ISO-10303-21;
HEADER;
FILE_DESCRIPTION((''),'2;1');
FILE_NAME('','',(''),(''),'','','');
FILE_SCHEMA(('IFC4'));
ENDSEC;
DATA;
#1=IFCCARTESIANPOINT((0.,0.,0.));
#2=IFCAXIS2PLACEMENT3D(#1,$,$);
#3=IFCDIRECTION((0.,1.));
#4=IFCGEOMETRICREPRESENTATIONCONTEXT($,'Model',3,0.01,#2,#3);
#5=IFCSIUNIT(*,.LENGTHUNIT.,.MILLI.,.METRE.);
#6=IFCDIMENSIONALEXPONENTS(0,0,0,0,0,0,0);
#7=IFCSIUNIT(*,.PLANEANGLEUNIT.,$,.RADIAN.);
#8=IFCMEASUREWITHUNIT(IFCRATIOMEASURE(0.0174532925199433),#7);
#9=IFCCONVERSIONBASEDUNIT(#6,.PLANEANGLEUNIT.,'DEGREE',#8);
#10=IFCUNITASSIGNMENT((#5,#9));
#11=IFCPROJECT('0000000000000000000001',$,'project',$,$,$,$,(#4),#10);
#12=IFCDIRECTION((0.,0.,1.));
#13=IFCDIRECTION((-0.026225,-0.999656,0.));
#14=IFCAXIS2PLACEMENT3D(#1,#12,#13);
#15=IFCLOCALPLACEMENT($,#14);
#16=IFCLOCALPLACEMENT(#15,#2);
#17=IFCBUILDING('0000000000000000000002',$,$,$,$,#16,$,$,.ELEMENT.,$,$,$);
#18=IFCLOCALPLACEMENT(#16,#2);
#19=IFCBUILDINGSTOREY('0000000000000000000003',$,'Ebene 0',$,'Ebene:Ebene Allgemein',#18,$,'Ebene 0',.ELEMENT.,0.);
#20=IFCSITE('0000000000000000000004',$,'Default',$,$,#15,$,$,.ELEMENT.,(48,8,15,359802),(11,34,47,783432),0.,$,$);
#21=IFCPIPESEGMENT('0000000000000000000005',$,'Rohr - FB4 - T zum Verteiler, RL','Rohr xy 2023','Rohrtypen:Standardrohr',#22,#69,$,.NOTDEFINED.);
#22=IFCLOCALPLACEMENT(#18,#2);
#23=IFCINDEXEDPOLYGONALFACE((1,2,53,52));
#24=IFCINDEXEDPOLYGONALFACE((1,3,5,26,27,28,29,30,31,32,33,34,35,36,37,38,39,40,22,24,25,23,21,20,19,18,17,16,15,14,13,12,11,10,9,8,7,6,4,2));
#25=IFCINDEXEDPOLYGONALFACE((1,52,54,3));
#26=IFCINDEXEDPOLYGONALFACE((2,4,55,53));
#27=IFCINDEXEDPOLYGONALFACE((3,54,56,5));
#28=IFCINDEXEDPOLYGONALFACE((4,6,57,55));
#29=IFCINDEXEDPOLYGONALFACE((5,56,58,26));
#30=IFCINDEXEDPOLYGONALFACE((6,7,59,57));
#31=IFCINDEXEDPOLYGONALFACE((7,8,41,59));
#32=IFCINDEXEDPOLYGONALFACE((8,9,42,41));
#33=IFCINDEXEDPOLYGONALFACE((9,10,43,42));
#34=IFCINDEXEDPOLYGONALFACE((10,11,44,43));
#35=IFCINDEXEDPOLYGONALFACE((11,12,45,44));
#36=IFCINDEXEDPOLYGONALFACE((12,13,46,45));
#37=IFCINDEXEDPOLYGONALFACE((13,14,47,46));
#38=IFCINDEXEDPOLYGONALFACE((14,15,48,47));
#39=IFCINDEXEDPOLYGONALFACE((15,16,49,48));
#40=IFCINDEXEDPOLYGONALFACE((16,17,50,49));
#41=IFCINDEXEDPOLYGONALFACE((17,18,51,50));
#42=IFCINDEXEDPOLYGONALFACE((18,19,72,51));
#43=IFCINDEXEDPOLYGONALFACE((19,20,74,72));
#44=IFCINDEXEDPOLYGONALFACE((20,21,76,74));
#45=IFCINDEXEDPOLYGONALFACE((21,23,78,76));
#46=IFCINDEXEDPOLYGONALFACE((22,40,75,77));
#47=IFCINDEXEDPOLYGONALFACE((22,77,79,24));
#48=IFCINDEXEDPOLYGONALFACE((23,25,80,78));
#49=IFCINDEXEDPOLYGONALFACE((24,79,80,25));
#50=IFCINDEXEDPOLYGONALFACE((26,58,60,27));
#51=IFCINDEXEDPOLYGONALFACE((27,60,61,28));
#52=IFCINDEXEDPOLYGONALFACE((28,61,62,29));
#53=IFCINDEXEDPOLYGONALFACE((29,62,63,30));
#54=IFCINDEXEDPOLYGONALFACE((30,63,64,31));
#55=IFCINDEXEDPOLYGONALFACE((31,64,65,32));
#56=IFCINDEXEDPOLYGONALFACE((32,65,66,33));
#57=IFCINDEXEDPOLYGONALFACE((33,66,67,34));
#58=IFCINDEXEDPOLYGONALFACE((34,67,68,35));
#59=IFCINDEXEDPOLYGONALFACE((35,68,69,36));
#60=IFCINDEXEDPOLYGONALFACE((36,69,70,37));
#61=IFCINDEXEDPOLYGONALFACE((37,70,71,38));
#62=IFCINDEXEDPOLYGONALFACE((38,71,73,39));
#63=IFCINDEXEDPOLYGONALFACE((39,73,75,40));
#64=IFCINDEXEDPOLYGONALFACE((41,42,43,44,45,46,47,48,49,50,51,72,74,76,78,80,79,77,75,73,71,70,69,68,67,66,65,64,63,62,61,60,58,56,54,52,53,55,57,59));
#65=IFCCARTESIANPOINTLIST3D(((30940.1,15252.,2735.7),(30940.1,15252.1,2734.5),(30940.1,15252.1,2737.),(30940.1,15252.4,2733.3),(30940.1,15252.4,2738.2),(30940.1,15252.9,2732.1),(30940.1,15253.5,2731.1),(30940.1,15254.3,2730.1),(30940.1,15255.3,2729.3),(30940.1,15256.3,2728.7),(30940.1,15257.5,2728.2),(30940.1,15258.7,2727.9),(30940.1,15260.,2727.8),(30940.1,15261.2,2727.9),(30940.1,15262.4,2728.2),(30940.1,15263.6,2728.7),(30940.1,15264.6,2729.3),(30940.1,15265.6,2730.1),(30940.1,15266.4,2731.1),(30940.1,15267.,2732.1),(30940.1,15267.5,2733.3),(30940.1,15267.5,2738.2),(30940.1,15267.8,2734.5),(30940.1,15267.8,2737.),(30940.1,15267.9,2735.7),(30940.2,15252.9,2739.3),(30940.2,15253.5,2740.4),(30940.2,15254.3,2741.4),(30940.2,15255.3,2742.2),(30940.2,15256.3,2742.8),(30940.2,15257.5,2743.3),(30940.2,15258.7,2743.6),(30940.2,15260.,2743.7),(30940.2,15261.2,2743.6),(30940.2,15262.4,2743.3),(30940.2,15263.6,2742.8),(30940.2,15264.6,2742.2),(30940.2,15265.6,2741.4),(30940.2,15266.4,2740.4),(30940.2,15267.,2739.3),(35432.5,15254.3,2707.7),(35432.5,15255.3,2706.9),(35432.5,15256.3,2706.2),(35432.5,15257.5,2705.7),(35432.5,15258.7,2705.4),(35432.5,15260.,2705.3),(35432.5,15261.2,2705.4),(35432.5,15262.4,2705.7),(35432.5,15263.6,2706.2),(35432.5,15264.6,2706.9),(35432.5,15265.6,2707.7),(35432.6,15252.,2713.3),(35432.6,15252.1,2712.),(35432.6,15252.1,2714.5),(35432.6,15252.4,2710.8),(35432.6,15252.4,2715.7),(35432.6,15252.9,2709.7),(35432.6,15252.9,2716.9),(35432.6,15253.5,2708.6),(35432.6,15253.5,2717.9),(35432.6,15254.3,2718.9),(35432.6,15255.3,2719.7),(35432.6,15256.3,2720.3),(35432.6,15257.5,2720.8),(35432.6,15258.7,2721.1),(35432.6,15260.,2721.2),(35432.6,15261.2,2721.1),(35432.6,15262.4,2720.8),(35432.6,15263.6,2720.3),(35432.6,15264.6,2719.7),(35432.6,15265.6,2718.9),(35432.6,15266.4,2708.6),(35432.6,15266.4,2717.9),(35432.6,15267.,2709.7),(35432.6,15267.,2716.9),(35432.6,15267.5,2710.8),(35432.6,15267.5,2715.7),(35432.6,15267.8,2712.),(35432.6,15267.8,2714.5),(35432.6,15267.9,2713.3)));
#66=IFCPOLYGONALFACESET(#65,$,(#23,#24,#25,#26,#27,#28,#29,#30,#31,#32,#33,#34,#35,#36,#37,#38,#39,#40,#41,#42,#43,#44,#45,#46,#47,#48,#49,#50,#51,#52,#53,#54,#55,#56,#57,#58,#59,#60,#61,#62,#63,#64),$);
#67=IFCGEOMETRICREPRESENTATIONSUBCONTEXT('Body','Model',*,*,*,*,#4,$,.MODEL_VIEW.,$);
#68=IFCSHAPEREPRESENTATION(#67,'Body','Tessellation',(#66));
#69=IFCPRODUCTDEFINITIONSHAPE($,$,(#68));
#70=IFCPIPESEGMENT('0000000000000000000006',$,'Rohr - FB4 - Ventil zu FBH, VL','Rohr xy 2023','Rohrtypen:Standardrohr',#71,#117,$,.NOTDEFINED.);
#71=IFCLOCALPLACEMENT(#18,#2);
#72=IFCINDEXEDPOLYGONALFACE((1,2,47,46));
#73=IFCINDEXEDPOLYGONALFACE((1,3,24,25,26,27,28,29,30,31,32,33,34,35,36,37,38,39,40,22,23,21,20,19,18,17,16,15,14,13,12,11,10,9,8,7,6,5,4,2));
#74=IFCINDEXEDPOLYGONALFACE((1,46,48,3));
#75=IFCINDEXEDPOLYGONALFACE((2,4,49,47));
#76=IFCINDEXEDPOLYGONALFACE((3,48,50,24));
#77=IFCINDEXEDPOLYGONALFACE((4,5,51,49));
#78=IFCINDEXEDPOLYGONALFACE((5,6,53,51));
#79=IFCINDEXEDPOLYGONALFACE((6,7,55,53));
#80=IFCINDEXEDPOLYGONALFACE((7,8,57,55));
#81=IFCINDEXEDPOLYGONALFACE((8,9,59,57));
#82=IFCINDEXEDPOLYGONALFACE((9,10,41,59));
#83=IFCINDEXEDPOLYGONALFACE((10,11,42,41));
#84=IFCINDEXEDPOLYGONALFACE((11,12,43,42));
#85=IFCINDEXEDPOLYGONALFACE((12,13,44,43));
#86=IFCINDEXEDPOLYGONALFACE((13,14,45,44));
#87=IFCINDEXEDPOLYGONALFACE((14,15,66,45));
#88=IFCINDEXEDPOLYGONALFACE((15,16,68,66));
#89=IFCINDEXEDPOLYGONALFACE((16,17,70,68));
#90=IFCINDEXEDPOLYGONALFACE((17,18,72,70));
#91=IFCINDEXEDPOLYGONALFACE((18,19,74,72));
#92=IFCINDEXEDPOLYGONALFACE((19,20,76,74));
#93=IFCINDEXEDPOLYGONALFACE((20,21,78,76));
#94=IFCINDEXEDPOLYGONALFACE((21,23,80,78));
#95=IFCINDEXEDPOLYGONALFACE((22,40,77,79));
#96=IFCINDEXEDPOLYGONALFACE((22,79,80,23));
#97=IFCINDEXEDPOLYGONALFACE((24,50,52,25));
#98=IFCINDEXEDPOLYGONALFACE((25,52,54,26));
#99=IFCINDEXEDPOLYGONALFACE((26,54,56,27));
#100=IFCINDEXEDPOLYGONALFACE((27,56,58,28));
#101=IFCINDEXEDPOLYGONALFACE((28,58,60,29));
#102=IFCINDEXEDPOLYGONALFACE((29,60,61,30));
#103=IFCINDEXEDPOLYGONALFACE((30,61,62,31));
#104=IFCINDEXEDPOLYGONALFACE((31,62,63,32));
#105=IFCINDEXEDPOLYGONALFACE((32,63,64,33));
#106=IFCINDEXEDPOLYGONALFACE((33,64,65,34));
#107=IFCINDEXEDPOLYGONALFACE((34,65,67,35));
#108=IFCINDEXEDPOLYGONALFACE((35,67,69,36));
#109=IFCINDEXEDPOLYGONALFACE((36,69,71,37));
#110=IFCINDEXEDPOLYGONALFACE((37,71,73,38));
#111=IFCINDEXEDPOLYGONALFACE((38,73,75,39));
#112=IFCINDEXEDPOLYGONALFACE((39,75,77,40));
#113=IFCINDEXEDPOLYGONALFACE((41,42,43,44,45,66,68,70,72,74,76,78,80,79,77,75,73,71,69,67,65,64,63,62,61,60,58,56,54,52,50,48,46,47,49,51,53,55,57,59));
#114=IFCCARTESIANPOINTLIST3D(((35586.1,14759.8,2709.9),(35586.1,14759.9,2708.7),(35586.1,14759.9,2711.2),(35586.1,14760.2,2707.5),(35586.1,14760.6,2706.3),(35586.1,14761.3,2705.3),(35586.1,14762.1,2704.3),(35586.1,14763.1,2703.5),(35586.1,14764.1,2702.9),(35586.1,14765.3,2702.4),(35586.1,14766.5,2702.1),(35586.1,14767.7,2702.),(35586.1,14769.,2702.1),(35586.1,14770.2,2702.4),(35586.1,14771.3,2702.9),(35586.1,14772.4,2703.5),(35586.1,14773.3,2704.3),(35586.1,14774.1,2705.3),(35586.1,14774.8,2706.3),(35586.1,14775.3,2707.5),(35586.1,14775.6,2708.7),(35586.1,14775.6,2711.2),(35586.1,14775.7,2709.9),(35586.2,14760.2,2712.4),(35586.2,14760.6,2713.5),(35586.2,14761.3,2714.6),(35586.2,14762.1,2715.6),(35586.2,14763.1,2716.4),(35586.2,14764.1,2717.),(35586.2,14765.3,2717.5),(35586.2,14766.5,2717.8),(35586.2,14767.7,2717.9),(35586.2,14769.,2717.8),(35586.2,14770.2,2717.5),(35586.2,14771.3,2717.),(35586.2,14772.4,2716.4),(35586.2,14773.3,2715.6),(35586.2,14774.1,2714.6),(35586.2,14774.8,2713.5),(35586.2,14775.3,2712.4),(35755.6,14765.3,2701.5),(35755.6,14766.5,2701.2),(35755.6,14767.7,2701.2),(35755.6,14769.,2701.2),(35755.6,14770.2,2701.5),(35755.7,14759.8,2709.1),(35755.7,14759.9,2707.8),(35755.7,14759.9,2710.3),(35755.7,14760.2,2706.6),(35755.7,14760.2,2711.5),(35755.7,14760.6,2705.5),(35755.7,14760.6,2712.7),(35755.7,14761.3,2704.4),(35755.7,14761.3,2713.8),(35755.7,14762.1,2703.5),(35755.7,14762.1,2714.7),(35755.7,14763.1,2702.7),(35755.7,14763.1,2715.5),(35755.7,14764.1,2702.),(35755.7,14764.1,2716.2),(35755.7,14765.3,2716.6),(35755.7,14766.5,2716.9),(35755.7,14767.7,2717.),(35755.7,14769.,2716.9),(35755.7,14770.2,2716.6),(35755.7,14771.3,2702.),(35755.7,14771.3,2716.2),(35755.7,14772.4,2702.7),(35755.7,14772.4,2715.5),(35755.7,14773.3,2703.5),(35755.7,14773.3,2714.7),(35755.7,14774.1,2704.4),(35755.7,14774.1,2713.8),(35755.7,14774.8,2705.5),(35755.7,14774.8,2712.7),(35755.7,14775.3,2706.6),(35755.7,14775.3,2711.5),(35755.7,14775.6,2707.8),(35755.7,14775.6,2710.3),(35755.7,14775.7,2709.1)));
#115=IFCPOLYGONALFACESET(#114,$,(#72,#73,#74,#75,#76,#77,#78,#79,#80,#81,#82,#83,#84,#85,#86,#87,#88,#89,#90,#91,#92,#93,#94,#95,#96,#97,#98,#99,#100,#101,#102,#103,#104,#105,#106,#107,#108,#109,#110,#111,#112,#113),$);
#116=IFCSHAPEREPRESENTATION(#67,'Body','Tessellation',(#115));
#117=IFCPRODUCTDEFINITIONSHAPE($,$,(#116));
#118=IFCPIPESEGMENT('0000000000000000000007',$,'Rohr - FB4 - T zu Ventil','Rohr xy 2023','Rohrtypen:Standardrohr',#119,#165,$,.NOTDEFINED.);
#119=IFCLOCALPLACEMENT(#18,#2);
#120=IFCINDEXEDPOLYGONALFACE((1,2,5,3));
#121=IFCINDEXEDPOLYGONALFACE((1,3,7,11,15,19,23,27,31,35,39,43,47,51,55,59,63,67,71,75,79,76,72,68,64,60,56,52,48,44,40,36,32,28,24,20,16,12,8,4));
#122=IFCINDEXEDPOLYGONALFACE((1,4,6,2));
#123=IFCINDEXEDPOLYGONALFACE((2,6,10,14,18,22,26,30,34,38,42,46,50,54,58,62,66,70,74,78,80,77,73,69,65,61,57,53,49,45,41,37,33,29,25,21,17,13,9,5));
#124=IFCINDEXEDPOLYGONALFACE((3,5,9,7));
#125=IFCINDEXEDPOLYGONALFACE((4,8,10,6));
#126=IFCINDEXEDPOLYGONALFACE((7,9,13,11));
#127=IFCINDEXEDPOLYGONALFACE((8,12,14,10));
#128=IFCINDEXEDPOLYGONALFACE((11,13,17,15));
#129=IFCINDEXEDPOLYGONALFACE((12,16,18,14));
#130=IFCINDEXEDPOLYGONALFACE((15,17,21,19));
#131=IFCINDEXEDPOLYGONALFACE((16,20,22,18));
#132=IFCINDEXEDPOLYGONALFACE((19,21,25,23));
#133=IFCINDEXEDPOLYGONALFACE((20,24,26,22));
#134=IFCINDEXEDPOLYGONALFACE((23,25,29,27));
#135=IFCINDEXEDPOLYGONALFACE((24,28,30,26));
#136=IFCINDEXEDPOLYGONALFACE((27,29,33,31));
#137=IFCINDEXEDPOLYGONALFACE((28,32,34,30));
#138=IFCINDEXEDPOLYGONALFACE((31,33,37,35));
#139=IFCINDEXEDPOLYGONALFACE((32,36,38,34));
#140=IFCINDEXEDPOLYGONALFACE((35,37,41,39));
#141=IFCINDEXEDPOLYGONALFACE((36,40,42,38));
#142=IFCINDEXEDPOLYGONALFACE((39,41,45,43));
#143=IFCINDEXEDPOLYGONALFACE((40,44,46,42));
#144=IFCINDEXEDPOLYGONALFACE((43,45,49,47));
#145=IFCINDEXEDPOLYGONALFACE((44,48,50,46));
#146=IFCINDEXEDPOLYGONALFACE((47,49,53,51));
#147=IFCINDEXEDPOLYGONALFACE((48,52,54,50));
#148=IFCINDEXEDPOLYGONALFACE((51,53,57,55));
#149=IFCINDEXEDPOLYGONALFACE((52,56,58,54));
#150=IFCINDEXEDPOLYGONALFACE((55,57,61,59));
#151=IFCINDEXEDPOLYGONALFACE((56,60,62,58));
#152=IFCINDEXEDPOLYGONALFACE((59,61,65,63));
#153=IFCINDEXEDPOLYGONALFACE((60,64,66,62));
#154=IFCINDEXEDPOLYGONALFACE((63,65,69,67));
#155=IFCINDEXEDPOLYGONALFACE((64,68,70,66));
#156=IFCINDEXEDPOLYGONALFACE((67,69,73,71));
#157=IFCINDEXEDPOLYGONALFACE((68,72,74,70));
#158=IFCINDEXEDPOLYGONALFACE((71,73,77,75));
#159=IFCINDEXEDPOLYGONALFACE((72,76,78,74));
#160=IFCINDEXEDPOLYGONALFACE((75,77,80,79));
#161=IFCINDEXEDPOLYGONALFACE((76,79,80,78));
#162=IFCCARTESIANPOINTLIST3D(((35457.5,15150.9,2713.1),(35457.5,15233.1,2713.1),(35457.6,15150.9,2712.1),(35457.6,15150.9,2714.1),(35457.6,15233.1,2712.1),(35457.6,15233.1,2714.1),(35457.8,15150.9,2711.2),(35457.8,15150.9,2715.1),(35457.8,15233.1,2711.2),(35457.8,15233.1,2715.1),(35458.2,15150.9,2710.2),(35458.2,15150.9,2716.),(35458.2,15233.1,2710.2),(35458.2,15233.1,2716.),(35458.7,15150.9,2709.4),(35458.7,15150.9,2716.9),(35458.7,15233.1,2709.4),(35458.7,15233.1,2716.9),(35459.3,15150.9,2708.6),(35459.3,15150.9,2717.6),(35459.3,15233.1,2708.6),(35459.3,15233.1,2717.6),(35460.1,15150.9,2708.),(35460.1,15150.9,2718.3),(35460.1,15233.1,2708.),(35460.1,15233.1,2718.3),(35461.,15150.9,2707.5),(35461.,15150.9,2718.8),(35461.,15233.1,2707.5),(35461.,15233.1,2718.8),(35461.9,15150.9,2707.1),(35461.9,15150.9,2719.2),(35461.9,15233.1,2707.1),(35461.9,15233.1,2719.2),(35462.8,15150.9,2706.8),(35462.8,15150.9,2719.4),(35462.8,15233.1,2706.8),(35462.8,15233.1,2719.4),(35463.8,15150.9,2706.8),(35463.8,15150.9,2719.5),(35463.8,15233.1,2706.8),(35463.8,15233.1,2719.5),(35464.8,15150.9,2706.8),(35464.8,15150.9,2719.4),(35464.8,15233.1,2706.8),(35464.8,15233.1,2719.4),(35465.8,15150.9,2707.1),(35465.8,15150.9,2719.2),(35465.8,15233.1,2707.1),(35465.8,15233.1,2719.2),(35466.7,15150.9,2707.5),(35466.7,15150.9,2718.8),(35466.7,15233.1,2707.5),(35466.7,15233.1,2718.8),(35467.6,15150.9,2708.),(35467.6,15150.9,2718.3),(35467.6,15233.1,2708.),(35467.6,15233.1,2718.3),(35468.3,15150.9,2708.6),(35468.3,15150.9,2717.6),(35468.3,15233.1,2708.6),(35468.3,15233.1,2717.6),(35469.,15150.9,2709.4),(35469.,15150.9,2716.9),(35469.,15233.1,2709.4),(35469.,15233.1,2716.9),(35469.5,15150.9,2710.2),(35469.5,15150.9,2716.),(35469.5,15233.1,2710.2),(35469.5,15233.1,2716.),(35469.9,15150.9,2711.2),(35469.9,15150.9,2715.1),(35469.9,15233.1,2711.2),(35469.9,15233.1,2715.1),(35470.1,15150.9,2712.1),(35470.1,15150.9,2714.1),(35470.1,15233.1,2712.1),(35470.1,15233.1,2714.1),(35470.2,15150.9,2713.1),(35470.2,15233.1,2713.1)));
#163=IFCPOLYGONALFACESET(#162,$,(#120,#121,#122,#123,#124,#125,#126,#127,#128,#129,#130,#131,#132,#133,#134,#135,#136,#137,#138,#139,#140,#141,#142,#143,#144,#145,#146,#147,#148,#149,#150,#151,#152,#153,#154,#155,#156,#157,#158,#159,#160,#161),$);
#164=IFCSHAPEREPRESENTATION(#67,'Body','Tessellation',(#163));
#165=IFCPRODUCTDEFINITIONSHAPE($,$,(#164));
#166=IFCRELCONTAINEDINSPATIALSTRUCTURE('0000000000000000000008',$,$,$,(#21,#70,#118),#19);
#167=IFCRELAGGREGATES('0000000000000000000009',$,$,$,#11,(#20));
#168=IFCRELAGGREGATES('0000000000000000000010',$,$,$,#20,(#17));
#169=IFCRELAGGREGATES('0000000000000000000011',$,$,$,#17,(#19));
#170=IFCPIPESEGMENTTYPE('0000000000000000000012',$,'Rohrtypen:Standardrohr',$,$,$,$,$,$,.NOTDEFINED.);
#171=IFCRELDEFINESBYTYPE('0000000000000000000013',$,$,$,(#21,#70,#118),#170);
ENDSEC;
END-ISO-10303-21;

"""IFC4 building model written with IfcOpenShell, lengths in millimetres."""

from ifc_helpers import new_model, entity, si_unit, converted_unit, direction, frame, origin, place, context, subcontext, project, spatial, indexed_curve, outline, extrude, type_object, element, save


model = new_model("IFC4")

# Units and contexts
model_context = context("Model", 3, precision=0.01, world=origin(), true_north=direction((0.0, 1.0)))
body_context = subcontext(model_context, "Body", "Model", "MODEL_VIEW")
ifc_project = project(units=[si_unit("LENGTHUNIT", "METRE", prefix="MILLI"), converted_unit("PLANEANGLEUNIT", "DEGREE", entity("IfcRatioMeasure", 0.0174532925199433), si_unit("PLANEANGLEUNIT", "RADIAN"), dimensions=[0, 0, 0, 0, 0, 0, 0])], contexts=[model_context])

# Site, building, storey
site_placement = place(None, frame((0.0, 0.0, 0.0), z_axis=(0.0, 0.0, 1.0), x_axis=(-0.026225, -0.999656, 0.0)))
site = spatial("IfcSite", under=ifc_project, at=site_placement, Name="Default", CompositionType="ELEMENT", RefLatitude=(48, 8, 15, 359802), RefLongitude=(11, 34, 47, 783432), RefElevation=0.0)
building_placement = place(site_placement, origin())
building = spatial("IfcBuilding", under=site, at=building_placement, CompositionType="ELEMENT")
storey_placement = place(building_placement, origin())
storey = spatial("IfcBuildingStorey", under=building, at=storey_placement, Name="Ebene 0", ObjectType="Ebene:Ebene Allgemein", LongName="Ebene 0", CompositionType="ELEMENT", Elevation=0.0)

# Pipe segments
pipe_segment_type = type_object("IfcPipeSegmentType", Name="Rohrtypen:Standardrohr", PredefinedType="NOTDEFINED")
pipe_segment_1_placement = place(storey_placement, origin())
element("IfcPipeSegment", 1, at=pipe_segment_1_placement, inside=storey, type_object=pipe_segment_type, Name="Rohr - FB4 - T zum Verteiler, RL", Description="Rohr xy 2023", ObjectType="Rohrtypen:Standardrohr", PredefinedType="NOTDEFINED", context=body_context, shape_type="SweptSolid", body=[
    extrude(outline(indexed_curve([(7.9, 0.0), (7.8, 1.2), (7.6, 2.5), (7.1, 3.6), (6.4, 4.7), (5.6, 5.6), (4.7, 6.4), (3.6, 7.1), (2.5, 7.6), (1.2, 7.8), (0.0, 7.9), (-1.2, 7.8), (-2.5, 7.6), (-3.6, 7.1), (-4.7, 6.4), (-5.6, 5.6), (-6.4, 4.7), (-7.1, 3.6), (-7.6, 2.5), (-7.8, 1.2), (-7.9, 0.0), (-7.8, -1.2), (-7.6, -2.5), (-7.1, -3.6), (-6.4, -4.7), (-5.6, -5.6), (-4.7, -6.4), (-3.6, -7.1), (-2.5, -7.6), (-1.2, -7.8), (0.0, -7.9), (1.2, -7.8), (2.5, -7.6), (3.6, -7.1), (4.7, -6.4), (5.6, -5.6), (6.4, -4.7), (7.1, -3.6), (7.6, -2.5), (7.8, -1.2), (7.9, 0.0)], self_intersect=False)), frame((35432.6, 15260.0, 2713.3), z_axis=(-0.999988, 0.0, 0.005), x_axis=(0.0, 1.0, 0.0)), (0.0, 0.0, 1.0), 4492.5),
])
pipe_segment_2_placement = place(storey_placement, origin())
element("IfcPipeSegment", 2, at=pipe_segment_2_placement, inside=storey, type_object=pipe_segment_type, Name="Rohr - FB4 - Ventil zu FBH, VL", Description="Rohr xy 2023", ObjectType="Rohrtypen:Standardrohr", PredefinedType="NOTDEFINED", context=body_context, shape_type="SweptSolid", body=[
    extrude(outline(indexed_curve([(7.9, 0.0), (7.8, 1.2), (7.6, 2.5), (7.1, 3.6), (6.4, 4.7), (5.6, 5.6), (4.7, 6.4), (3.6, 7.1), (2.5, 7.6), (1.2, 7.8), (0.0, 7.9), (-1.2, 7.8), (-2.5, 7.6), (-3.6, 7.1), (-4.7, 6.4), (-5.6, 5.6), (-6.4, 4.7), (-7.1, 3.6), (-7.6, 2.5), (-7.8, 1.2), (-7.9, 0.0), (-7.8, -1.2), (-7.6, -2.5), (-7.1, -3.6), (-6.4, -4.7), (-5.6, -5.6), (-4.7, -6.4), (-3.6, -7.1), (-2.5, -7.6), (-1.2, -7.8), (0.0, -7.9), (1.2, -7.8), (2.5, -7.6), (3.6, -7.1), (4.7, -6.4), (5.6, -5.6), (6.4, -4.7), (7.1, -3.6), (7.6, -2.5), (7.8, -1.2), (7.9, 0.0)], self_intersect=False)), frame((35586.1, 14767.7, 2709.9), z_axis=(0.999988, 0.0, -0.005), x_axis=(0.0, 1.0, 0.0)), (0.0, 0.0, 1.0), 169.5),
])
pipe_segment_3_placement = place(storey_placement, origin())
element("IfcPipeSegment", 3, at=pipe_segment_3_placement, inside=storey, type_object=pipe_segment_type, Name="Rohr - FB4 - T zu Ventil", Description="Rohr xy 2023", ObjectType="Rohrtypen:Standardrohr", PredefinedType="NOTDEFINED", context=body_context, shape_type="SweptSolid", body=[
    extrude(outline(indexed_curve([(6.3, 0.0), (6.3, 1.0), (6.0, 2.0), (5.7, 2.9), (5.1, 3.7), (4.5, 4.5), (3.7, 5.1), (2.9, 5.7), (2.0, 6.0), (1.0, 6.3), (0.0, 6.4), (-1.0, 6.3), (-2.0, 6.0), (-2.9, 5.7), (-3.7, 5.1), (-4.5, 4.5), (-5.1, 3.7), (-5.7, 2.9), (-6.0, 2.0), (-6.3, 1.0), (-6.3, 0.0), (-6.3, -1.0), (-6.0, -2.0), (-5.7, -2.9), (-5.1, -3.7), (-4.5, -4.5), (-3.7, -5.1), (-2.9, -5.7), (-2.0, -6.0), (-1.0, -6.3), (0.0, -6.4), (1.0, -6.3), (2.0, -6.0), (2.9, -5.7), (3.7, -5.1), (4.5, -4.5), (5.1, -3.7), (5.7, -2.9), (6.0, -2.0), (6.3, -1.0), (6.3, 0.0)], self_intersect=False)), frame((35463.8, 15150.9, 2713.1), z_axis=(0.0, 1.0, 0.0), x_axis=(-1.0, 0.0, 0.0)), (0.0, 0.0, 1.0), 82.2),
])

save(model, "model.ifc")
